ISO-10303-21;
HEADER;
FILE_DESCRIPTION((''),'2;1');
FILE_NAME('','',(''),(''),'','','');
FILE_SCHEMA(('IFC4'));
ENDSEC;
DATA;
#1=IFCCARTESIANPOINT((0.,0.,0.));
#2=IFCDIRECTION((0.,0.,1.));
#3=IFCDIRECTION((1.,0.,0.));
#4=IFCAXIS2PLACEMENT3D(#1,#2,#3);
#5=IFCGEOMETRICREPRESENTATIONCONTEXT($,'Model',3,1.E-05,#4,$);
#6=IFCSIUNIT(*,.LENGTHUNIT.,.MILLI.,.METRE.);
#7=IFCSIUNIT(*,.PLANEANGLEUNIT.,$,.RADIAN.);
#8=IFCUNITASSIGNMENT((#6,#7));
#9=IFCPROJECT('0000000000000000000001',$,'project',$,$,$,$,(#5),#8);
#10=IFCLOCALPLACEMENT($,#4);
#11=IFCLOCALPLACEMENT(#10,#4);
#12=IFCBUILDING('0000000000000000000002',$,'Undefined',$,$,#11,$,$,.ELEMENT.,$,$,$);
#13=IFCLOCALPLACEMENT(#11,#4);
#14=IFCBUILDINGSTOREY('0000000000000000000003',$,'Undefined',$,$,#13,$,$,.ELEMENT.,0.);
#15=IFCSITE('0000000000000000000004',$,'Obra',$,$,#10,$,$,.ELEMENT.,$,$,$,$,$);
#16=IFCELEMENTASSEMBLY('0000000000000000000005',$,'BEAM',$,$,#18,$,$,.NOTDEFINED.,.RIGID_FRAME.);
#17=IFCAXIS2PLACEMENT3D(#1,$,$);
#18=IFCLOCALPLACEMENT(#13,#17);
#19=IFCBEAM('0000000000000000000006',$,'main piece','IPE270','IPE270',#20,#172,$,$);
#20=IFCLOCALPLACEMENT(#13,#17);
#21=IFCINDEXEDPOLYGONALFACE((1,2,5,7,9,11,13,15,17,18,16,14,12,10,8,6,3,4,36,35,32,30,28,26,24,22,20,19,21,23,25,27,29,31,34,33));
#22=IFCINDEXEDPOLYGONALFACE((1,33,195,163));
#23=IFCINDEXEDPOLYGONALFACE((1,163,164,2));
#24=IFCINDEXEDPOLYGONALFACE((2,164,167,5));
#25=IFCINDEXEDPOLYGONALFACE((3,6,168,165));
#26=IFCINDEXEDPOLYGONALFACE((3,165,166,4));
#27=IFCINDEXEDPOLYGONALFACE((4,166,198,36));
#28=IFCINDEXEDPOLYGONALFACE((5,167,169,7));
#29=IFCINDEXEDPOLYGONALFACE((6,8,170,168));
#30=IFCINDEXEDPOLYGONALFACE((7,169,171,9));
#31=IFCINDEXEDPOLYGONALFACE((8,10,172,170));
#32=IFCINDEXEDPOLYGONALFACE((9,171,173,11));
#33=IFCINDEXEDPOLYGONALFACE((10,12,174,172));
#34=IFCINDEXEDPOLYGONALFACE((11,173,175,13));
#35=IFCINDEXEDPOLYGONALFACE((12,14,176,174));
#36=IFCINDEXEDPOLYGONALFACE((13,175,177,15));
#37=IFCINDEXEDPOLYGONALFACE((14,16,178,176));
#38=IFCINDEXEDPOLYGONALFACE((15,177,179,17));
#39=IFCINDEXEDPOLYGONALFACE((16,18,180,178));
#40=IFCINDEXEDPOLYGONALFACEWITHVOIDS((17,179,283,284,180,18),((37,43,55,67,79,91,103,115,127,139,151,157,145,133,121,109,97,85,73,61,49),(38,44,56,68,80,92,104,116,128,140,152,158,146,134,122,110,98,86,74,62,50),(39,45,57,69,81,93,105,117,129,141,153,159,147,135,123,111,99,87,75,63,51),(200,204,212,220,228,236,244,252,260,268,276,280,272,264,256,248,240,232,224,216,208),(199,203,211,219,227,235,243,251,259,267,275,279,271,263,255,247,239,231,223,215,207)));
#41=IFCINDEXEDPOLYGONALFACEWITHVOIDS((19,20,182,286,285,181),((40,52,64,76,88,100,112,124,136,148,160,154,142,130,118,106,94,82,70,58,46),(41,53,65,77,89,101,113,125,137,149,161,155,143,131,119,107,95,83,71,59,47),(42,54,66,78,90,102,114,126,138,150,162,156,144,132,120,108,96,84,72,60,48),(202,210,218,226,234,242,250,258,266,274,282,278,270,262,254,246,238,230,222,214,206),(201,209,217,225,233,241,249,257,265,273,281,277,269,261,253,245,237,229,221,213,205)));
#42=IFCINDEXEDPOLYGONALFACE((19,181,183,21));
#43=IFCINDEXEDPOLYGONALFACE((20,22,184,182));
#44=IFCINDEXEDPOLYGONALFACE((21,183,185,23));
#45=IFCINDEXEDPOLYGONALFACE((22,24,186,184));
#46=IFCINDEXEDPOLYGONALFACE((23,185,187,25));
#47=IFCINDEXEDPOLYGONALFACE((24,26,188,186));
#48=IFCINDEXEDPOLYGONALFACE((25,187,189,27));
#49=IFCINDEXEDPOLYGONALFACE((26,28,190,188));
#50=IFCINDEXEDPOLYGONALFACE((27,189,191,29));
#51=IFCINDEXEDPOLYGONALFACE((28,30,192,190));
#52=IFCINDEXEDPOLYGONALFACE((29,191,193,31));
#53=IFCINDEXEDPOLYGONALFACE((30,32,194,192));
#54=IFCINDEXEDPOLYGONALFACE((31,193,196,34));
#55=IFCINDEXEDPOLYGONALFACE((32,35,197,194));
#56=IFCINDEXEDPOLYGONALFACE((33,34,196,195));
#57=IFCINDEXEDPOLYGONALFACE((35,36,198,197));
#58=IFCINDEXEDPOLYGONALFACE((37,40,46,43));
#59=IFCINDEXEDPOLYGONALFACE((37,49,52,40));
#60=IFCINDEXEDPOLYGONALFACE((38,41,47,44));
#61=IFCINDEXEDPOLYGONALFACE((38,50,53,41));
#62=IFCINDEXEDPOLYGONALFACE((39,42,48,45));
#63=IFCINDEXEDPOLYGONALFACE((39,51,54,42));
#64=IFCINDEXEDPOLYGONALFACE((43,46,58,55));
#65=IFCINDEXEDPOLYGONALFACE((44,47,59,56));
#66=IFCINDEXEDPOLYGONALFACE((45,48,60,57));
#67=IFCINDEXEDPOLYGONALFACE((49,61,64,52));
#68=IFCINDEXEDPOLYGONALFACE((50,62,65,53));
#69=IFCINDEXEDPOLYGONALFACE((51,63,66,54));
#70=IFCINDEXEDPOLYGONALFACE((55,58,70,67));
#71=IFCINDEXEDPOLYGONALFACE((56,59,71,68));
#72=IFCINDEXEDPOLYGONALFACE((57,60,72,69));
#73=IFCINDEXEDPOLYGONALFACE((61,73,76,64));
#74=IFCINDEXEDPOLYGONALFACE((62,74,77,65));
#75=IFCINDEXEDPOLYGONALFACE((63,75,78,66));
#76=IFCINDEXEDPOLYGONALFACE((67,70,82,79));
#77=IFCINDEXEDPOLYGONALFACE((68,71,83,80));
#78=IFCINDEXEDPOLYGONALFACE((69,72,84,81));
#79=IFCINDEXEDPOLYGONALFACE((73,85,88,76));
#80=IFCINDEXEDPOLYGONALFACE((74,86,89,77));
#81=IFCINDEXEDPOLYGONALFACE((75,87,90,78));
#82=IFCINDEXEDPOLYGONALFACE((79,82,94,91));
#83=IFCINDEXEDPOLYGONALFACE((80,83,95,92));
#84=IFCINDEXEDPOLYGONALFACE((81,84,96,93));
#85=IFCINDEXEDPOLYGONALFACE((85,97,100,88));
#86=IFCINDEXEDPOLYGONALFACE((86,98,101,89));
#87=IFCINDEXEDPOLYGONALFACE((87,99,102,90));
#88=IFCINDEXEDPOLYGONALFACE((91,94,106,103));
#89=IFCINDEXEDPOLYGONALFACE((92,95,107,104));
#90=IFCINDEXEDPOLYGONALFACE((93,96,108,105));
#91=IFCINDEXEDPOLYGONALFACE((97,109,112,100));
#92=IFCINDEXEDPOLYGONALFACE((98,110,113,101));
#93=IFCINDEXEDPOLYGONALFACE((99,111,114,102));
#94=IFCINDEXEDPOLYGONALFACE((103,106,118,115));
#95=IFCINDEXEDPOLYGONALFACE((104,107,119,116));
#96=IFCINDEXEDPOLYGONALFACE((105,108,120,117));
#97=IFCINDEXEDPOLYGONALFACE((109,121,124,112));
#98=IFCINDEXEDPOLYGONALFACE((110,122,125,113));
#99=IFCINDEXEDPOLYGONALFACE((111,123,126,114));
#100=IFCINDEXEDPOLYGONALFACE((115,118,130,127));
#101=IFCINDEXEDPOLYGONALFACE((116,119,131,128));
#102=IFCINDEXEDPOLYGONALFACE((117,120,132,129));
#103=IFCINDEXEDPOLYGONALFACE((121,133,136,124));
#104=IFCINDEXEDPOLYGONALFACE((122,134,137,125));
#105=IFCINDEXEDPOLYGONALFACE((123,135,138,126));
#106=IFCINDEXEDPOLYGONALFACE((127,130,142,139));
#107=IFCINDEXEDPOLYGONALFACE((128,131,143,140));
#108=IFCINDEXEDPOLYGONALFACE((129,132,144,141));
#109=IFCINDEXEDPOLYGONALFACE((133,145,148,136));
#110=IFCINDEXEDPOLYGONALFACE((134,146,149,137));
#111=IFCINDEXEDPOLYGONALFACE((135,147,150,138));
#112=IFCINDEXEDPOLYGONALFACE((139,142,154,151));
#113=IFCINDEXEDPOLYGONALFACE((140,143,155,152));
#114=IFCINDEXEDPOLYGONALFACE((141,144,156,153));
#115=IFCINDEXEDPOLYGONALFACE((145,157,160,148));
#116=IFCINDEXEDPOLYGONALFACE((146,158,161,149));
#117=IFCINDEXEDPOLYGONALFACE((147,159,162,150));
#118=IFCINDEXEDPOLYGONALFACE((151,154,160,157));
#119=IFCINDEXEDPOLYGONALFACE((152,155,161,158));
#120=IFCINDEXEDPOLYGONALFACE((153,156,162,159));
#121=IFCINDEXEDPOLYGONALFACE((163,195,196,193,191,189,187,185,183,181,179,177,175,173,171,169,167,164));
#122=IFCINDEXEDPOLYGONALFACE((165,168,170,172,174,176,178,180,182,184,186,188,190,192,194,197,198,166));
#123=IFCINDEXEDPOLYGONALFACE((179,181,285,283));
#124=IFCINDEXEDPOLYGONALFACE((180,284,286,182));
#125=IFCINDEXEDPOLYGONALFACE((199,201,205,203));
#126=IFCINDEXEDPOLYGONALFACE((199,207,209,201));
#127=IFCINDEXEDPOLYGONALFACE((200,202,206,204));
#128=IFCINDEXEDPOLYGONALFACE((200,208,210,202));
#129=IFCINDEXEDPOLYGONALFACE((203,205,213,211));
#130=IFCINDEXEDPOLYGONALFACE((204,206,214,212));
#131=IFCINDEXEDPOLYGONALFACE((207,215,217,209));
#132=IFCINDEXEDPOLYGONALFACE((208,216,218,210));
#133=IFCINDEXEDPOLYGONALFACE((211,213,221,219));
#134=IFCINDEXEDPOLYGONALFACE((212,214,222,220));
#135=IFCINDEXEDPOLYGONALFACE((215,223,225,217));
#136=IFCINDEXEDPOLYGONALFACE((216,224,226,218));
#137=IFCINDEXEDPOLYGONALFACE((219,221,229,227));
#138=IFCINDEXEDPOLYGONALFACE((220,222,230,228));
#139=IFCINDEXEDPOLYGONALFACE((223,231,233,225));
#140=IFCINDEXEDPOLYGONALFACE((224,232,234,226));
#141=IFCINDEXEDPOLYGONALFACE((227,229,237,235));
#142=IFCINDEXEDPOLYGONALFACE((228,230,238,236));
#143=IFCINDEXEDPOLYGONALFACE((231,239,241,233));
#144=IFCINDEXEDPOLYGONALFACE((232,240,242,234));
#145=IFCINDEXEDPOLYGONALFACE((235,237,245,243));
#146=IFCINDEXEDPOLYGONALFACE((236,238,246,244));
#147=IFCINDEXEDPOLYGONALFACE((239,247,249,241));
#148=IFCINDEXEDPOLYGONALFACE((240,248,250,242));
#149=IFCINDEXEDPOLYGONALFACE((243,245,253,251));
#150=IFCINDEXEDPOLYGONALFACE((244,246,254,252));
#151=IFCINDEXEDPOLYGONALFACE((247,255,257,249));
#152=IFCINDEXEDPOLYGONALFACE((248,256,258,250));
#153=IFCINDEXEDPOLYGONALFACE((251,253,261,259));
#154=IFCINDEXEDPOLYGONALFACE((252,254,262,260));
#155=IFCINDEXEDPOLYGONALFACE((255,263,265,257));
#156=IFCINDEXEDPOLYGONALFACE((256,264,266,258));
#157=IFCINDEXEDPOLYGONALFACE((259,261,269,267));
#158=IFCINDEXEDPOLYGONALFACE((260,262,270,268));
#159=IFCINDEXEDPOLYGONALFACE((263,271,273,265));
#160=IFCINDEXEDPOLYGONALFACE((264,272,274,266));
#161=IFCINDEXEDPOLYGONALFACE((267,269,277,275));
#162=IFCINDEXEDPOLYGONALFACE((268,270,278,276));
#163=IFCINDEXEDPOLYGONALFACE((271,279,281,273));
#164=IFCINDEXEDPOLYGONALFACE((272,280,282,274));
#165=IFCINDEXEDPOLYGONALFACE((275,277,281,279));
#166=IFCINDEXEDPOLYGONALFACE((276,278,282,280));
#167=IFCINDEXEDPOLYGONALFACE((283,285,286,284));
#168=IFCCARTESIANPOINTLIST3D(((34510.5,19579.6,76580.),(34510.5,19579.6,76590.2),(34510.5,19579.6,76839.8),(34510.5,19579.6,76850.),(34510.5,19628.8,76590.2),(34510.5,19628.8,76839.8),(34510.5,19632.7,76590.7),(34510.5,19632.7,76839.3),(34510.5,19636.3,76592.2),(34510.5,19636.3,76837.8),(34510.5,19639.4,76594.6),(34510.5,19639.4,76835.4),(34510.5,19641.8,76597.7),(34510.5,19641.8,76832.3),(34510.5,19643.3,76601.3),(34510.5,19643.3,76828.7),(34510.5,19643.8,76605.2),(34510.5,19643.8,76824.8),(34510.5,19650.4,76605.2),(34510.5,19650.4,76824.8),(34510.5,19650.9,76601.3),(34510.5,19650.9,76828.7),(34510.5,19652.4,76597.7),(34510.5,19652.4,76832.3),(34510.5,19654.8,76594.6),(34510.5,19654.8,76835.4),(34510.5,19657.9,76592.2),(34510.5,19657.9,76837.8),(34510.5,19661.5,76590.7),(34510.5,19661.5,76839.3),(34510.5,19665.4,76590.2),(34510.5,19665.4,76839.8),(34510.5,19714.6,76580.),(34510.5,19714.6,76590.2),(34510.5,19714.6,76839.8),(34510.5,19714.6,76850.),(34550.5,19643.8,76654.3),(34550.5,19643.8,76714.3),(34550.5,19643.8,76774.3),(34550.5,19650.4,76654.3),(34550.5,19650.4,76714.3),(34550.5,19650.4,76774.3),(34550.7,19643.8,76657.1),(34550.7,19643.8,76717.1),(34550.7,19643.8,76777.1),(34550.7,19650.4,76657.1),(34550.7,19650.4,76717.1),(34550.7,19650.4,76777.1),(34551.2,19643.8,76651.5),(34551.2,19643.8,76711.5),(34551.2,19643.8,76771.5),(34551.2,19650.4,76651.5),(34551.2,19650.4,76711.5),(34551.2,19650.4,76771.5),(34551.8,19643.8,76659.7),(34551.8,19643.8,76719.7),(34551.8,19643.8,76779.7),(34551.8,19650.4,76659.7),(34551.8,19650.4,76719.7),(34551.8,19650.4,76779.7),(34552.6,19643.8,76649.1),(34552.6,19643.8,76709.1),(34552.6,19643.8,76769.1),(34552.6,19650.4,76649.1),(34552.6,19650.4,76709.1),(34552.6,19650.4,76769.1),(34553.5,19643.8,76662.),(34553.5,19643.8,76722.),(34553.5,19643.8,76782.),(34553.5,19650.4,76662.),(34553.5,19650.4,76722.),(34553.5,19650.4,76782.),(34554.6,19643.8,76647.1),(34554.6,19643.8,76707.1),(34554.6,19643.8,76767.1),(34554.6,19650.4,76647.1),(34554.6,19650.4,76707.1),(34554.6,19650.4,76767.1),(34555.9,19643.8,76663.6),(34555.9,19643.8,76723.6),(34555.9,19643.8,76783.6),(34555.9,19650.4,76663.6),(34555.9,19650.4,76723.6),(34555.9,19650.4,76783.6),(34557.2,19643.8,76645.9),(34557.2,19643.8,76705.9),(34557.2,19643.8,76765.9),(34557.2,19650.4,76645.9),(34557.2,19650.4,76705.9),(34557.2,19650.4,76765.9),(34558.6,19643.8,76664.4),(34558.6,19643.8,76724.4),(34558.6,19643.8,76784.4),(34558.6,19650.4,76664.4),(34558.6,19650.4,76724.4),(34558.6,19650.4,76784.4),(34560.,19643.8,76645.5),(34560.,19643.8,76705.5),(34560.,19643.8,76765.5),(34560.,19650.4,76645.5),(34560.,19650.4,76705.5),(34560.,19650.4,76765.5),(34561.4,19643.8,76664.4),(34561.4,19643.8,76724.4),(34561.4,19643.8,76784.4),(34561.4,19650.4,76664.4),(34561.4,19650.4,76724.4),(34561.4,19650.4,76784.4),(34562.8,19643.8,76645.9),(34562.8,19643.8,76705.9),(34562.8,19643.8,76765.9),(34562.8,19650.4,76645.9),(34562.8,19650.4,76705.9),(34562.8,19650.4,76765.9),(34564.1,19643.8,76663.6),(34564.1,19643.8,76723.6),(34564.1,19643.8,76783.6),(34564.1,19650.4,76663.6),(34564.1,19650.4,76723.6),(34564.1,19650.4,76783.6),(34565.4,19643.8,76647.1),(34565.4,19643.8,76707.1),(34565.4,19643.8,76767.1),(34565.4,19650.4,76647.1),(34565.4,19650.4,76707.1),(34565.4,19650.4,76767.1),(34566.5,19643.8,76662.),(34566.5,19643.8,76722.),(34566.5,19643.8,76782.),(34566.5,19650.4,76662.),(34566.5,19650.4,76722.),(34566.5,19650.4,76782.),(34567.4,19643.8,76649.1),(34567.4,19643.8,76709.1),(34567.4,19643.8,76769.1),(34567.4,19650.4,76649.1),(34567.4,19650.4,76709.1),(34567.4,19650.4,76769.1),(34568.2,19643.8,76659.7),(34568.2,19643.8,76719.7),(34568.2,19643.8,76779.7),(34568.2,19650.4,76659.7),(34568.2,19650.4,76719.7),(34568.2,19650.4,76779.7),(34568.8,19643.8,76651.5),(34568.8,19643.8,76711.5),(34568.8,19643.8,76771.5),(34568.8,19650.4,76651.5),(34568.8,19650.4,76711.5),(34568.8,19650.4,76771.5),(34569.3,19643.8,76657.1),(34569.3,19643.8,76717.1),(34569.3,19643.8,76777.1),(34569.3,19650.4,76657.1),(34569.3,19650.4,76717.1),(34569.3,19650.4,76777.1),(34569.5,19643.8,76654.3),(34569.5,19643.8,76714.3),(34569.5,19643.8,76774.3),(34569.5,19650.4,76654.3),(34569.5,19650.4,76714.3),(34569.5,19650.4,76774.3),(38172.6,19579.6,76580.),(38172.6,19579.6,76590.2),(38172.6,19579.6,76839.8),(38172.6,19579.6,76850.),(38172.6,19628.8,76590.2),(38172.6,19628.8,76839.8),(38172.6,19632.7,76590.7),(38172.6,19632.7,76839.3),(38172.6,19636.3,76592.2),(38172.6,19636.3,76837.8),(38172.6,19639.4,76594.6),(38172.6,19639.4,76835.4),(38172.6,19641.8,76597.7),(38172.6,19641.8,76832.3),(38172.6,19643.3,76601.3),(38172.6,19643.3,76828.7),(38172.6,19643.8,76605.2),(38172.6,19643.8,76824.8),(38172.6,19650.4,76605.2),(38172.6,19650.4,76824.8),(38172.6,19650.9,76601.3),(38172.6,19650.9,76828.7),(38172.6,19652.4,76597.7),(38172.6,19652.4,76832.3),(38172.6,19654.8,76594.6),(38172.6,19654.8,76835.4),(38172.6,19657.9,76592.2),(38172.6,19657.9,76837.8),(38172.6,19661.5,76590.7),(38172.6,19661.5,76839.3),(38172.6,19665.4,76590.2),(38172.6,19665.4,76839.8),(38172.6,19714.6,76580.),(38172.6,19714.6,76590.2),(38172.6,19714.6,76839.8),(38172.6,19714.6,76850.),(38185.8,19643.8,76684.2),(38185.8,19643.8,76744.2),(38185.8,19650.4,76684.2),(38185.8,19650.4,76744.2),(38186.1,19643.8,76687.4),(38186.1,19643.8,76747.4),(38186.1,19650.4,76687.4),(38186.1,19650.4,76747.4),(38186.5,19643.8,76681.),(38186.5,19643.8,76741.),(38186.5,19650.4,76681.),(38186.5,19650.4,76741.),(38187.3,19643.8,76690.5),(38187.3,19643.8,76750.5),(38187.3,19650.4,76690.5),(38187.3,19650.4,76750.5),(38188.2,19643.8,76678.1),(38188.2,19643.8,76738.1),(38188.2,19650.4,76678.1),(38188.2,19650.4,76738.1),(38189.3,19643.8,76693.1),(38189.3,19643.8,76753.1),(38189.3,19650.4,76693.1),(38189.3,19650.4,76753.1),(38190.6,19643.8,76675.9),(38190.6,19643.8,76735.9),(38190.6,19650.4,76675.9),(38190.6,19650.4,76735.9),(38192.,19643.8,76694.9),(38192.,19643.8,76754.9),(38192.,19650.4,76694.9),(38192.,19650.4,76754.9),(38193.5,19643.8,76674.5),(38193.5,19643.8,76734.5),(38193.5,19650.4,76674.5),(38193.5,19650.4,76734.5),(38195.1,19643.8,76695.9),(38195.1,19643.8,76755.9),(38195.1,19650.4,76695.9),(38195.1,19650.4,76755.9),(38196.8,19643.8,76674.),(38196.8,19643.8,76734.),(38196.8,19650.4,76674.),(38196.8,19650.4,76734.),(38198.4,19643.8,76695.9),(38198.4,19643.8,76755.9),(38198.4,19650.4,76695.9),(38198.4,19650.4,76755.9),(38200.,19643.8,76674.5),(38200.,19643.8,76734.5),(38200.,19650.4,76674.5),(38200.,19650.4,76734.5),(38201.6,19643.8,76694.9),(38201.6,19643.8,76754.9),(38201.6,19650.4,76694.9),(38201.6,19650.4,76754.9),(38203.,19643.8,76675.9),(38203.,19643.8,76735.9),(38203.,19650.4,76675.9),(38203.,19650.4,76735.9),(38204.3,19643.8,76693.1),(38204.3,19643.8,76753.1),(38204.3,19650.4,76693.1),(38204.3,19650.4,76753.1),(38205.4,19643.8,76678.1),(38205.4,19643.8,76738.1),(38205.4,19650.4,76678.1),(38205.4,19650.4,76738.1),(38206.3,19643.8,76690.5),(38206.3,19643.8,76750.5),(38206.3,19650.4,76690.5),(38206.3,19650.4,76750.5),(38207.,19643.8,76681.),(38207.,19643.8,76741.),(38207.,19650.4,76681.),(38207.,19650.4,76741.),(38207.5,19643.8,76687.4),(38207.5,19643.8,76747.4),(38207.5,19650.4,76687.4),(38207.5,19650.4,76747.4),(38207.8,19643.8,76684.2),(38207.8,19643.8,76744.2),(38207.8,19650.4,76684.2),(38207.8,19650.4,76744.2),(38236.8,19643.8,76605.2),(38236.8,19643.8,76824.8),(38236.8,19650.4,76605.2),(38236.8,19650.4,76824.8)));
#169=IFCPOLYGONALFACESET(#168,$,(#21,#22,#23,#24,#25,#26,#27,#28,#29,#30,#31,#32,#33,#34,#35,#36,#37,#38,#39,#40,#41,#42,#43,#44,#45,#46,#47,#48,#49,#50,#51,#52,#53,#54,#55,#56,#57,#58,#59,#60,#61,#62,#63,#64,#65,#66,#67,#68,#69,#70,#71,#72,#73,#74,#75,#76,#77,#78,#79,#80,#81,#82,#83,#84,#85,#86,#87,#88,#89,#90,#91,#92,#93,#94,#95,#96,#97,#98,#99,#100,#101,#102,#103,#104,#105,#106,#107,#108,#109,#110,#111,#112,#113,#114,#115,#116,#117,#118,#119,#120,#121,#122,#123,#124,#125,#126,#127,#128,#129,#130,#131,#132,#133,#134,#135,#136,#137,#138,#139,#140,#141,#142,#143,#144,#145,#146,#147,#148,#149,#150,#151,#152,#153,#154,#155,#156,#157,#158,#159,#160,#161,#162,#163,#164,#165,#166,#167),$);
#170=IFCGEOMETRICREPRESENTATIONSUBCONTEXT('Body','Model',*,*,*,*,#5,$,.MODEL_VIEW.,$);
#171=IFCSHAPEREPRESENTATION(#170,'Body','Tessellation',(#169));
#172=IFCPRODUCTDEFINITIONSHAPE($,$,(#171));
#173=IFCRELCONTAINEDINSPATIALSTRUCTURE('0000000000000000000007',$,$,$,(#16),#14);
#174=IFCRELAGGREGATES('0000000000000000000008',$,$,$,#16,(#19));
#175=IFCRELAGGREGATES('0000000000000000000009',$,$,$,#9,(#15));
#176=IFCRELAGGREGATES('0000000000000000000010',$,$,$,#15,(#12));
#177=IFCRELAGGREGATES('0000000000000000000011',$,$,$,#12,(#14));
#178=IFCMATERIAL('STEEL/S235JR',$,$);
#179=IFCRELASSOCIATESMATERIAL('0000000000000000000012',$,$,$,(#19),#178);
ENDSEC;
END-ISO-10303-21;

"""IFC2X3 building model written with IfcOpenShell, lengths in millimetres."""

from ifc_helpers import new_model, si_unit, frame, origin_with_axes, origin_2d_with_axis, place, context, subcontext, project, spatial, rectangle, circle, i_section, extrude, clip, halfspace, source, transform, mapped, material, element, aggregate, save


model = new_model("IFC2X3")

# Units and contexts
model_context = context("Model", 3, precision=1e-05, world=origin_with_axes())
body_context = subcontext(model_context, "Body", "Model", "MODEL_VIEW")
ifc_project = project(units=[si_unit("LENGTHUNIT", "METRE", prefix="MILLI"), si_unit("PLANEANGLEUNIT", "RADIAN")], contexts=[model_context])

# Site, building, storey
site_placement = place(None, origin_with_axes())
site = spatial("IfcSite", under=ifc_project, at=site_placement, Name="Obra", CompositionType="ELEMENT")
building_placement = place(site_placement, origin_with_axes())
building = spatial("IfcBuilding", under=site, at=building_placement, Name="Undefined", CompositionType="ELEMENT")
storey_placement = place(building_placement, origin_with_axes())
storey = spatial("IfcBuildingStorey", under=building, at=storey_placement, Name="Undefined", CompositionType="ELEMENT", Elevation=0.0)

# Shared definitions
ifc_material = material(Name="STEEL/S235JR")

# Element assembly, beam, openings
assembly_1_placement = place(storey_placement, origin_with_axes())
assembly_1 = element("IfcElementAssembly", 1, at=assembly_1_placement, inside=storey, Name="BEAM", AssemblyPlace="NOTDEFINED", PredefinedType="RIGID_FRAME")
beam_1_placement = place(assembly_1_placement, frame((34272.7, 19647.1, 76715.0), z_axis=(0.0, 0.0, 1.0), x_axis=(1.0, 0.0, 0.0)))
beam_1 = element("IfcBeam", 2, at=beam_1_placement, material=ifc_material, Name="main piece", Description="IPE270", ObjectType="IPE270", context=body_context, shape_type="Clipping", body=[
    clip(clip(extrude(i_section(OverallWidth=135.0, OverallDepth=270.0, WebThickness=6.6, FlangeThickness=10.2, FilletRadius=15.0, at=origin_2d_with_axis()), frame((3964.1, 0.0, 0.0), z_axis=(-1.0, 0.0, 0.0), x_axis=(0.0, -1.0, 0.0)), (0.0, 0.0, 1.0), 3964.1), halfspace(frame((237.8, 60.0, -120.0), z_axis=(-1.0, -0.000019, 0.0), x_axis=(0.0, 0.0, 1.0)), False)), halfspace(frame((3964.1, 0.0, -235.0), z_axis=(-1.0, 0.0, 0.0), x_axis=(0.0, 1.0, 0.0)), True)),
])
opening_1_placement = place(assembly_1_placement, frame((34272.7, 19647.1, 76715.0), z_axis=(0.0, 0.0, 1.0), x_axis=(1.0, 0.0, 0.0)))
element("IfcOpeningElement", 3, at=opening_1_placement, cuts=beam_1, ObjectType="Recess", context=body_context, shape_type="SweptSolid", body=[
    extrude(rectangle(XDim=26.2, YDim=76.2, at=origin_2d_with_axis()), frame((3938.0, 68.5, -122.9), z_axis=(0.0, -1.0, 0.0), x_axis=(0.0, 0.0, -1.0)), (0.0, 0.0, 1.0), 137.0),
])
opening_2_placement = place(assembly_1_placement, frame((34272.7, 19647.1, 76715.0), z_axis=(0.0, 0.0, 1.0), x_axis=(1.0, 0.0, 0.0)))
element("IfcOpeningElement", 4, at=opening_2_placement, cuts=beam_1, ObjectType="Recess", context=body_context, shape_type="SweptSolid", body=[
    extrude(rectangle(XDim=26.2, YDim=76.2, at=origin_2d_with_axis()), frame((3938.0, 68.5, 122.9), z_axis=(0.0, -1.0, 0.0), x_axis=(0.0, 0.0, -1.0)), (0.0, 0.0, 1.0), 137.0),
])
shared_shape_1 = source(origin_with_axes(), body_context, "Body", "SweptSolid", [
    extrude(circle(Radius=11.0, at=origin_2d_with_axis()), frame((0.0, -3.4, 0.0), z_axis=(0.0, 1.0, 0.0), x_axis=(1.0, 0.0, 0.0)), (0.0, 0.0, 1.0), 6.8),
])
opening_3_placement = place(assembly_1_placement, frame((38236.8, 19647.1, 76850.0), z_axis=(-1.0, 0.0, 0.0), x_axis=(0.0, 0.0, -1.0)))
element("IfcOpeningElement", 5, at=opening_3_placement, cuts=beam_1, ObjectType="Opening", context=body_context, shape_type="MappedRepresentation", body=[
    mapped(shared_shape_1, transform((105.0, 0.0, 40.0))),
    mapped(shared_shape_1, transform((165.0, 0.0, 40.0))),
])
shared_shape_2 = source(origin_with_axes(), body_context, "Body", "SweptSolid", [
    extrude(circle(Radius=9.5, at=origin_2d_with_axis()), frame((0.0, -3.4, 0.0), z_axis=(0.0, 1.0, 0.0), x_axis=(1.0, 0.0, 0.0)), (0.0, 0.0, 1.0), 6.8),
])
opening_4_placement = place(assembly_1_placement, frame((34510.0, 19647.1, 76835.0), z_axis=(1.0, 0.0, 0.0), x_axis=(0.0, 0.0, -1.0)))
element("IfcOpeningElement", 6, at=opening_4_placement, cuts=beam_1, ObjectType="Opening", context=body_context, shape_type="MappedRepresentation", body=[
    mapped(shared_shape_2, transform((60.0, 0.0, 50.0))),
    mapped(shared_shape_2, transform((120.0, 0.0, 50.0))),
    mapped(shared_shape_2, transform((180.0, 0.0, 50.0))),
])
aggregate(assembly_1, [beam_1])

save(model, "model.ifc")
